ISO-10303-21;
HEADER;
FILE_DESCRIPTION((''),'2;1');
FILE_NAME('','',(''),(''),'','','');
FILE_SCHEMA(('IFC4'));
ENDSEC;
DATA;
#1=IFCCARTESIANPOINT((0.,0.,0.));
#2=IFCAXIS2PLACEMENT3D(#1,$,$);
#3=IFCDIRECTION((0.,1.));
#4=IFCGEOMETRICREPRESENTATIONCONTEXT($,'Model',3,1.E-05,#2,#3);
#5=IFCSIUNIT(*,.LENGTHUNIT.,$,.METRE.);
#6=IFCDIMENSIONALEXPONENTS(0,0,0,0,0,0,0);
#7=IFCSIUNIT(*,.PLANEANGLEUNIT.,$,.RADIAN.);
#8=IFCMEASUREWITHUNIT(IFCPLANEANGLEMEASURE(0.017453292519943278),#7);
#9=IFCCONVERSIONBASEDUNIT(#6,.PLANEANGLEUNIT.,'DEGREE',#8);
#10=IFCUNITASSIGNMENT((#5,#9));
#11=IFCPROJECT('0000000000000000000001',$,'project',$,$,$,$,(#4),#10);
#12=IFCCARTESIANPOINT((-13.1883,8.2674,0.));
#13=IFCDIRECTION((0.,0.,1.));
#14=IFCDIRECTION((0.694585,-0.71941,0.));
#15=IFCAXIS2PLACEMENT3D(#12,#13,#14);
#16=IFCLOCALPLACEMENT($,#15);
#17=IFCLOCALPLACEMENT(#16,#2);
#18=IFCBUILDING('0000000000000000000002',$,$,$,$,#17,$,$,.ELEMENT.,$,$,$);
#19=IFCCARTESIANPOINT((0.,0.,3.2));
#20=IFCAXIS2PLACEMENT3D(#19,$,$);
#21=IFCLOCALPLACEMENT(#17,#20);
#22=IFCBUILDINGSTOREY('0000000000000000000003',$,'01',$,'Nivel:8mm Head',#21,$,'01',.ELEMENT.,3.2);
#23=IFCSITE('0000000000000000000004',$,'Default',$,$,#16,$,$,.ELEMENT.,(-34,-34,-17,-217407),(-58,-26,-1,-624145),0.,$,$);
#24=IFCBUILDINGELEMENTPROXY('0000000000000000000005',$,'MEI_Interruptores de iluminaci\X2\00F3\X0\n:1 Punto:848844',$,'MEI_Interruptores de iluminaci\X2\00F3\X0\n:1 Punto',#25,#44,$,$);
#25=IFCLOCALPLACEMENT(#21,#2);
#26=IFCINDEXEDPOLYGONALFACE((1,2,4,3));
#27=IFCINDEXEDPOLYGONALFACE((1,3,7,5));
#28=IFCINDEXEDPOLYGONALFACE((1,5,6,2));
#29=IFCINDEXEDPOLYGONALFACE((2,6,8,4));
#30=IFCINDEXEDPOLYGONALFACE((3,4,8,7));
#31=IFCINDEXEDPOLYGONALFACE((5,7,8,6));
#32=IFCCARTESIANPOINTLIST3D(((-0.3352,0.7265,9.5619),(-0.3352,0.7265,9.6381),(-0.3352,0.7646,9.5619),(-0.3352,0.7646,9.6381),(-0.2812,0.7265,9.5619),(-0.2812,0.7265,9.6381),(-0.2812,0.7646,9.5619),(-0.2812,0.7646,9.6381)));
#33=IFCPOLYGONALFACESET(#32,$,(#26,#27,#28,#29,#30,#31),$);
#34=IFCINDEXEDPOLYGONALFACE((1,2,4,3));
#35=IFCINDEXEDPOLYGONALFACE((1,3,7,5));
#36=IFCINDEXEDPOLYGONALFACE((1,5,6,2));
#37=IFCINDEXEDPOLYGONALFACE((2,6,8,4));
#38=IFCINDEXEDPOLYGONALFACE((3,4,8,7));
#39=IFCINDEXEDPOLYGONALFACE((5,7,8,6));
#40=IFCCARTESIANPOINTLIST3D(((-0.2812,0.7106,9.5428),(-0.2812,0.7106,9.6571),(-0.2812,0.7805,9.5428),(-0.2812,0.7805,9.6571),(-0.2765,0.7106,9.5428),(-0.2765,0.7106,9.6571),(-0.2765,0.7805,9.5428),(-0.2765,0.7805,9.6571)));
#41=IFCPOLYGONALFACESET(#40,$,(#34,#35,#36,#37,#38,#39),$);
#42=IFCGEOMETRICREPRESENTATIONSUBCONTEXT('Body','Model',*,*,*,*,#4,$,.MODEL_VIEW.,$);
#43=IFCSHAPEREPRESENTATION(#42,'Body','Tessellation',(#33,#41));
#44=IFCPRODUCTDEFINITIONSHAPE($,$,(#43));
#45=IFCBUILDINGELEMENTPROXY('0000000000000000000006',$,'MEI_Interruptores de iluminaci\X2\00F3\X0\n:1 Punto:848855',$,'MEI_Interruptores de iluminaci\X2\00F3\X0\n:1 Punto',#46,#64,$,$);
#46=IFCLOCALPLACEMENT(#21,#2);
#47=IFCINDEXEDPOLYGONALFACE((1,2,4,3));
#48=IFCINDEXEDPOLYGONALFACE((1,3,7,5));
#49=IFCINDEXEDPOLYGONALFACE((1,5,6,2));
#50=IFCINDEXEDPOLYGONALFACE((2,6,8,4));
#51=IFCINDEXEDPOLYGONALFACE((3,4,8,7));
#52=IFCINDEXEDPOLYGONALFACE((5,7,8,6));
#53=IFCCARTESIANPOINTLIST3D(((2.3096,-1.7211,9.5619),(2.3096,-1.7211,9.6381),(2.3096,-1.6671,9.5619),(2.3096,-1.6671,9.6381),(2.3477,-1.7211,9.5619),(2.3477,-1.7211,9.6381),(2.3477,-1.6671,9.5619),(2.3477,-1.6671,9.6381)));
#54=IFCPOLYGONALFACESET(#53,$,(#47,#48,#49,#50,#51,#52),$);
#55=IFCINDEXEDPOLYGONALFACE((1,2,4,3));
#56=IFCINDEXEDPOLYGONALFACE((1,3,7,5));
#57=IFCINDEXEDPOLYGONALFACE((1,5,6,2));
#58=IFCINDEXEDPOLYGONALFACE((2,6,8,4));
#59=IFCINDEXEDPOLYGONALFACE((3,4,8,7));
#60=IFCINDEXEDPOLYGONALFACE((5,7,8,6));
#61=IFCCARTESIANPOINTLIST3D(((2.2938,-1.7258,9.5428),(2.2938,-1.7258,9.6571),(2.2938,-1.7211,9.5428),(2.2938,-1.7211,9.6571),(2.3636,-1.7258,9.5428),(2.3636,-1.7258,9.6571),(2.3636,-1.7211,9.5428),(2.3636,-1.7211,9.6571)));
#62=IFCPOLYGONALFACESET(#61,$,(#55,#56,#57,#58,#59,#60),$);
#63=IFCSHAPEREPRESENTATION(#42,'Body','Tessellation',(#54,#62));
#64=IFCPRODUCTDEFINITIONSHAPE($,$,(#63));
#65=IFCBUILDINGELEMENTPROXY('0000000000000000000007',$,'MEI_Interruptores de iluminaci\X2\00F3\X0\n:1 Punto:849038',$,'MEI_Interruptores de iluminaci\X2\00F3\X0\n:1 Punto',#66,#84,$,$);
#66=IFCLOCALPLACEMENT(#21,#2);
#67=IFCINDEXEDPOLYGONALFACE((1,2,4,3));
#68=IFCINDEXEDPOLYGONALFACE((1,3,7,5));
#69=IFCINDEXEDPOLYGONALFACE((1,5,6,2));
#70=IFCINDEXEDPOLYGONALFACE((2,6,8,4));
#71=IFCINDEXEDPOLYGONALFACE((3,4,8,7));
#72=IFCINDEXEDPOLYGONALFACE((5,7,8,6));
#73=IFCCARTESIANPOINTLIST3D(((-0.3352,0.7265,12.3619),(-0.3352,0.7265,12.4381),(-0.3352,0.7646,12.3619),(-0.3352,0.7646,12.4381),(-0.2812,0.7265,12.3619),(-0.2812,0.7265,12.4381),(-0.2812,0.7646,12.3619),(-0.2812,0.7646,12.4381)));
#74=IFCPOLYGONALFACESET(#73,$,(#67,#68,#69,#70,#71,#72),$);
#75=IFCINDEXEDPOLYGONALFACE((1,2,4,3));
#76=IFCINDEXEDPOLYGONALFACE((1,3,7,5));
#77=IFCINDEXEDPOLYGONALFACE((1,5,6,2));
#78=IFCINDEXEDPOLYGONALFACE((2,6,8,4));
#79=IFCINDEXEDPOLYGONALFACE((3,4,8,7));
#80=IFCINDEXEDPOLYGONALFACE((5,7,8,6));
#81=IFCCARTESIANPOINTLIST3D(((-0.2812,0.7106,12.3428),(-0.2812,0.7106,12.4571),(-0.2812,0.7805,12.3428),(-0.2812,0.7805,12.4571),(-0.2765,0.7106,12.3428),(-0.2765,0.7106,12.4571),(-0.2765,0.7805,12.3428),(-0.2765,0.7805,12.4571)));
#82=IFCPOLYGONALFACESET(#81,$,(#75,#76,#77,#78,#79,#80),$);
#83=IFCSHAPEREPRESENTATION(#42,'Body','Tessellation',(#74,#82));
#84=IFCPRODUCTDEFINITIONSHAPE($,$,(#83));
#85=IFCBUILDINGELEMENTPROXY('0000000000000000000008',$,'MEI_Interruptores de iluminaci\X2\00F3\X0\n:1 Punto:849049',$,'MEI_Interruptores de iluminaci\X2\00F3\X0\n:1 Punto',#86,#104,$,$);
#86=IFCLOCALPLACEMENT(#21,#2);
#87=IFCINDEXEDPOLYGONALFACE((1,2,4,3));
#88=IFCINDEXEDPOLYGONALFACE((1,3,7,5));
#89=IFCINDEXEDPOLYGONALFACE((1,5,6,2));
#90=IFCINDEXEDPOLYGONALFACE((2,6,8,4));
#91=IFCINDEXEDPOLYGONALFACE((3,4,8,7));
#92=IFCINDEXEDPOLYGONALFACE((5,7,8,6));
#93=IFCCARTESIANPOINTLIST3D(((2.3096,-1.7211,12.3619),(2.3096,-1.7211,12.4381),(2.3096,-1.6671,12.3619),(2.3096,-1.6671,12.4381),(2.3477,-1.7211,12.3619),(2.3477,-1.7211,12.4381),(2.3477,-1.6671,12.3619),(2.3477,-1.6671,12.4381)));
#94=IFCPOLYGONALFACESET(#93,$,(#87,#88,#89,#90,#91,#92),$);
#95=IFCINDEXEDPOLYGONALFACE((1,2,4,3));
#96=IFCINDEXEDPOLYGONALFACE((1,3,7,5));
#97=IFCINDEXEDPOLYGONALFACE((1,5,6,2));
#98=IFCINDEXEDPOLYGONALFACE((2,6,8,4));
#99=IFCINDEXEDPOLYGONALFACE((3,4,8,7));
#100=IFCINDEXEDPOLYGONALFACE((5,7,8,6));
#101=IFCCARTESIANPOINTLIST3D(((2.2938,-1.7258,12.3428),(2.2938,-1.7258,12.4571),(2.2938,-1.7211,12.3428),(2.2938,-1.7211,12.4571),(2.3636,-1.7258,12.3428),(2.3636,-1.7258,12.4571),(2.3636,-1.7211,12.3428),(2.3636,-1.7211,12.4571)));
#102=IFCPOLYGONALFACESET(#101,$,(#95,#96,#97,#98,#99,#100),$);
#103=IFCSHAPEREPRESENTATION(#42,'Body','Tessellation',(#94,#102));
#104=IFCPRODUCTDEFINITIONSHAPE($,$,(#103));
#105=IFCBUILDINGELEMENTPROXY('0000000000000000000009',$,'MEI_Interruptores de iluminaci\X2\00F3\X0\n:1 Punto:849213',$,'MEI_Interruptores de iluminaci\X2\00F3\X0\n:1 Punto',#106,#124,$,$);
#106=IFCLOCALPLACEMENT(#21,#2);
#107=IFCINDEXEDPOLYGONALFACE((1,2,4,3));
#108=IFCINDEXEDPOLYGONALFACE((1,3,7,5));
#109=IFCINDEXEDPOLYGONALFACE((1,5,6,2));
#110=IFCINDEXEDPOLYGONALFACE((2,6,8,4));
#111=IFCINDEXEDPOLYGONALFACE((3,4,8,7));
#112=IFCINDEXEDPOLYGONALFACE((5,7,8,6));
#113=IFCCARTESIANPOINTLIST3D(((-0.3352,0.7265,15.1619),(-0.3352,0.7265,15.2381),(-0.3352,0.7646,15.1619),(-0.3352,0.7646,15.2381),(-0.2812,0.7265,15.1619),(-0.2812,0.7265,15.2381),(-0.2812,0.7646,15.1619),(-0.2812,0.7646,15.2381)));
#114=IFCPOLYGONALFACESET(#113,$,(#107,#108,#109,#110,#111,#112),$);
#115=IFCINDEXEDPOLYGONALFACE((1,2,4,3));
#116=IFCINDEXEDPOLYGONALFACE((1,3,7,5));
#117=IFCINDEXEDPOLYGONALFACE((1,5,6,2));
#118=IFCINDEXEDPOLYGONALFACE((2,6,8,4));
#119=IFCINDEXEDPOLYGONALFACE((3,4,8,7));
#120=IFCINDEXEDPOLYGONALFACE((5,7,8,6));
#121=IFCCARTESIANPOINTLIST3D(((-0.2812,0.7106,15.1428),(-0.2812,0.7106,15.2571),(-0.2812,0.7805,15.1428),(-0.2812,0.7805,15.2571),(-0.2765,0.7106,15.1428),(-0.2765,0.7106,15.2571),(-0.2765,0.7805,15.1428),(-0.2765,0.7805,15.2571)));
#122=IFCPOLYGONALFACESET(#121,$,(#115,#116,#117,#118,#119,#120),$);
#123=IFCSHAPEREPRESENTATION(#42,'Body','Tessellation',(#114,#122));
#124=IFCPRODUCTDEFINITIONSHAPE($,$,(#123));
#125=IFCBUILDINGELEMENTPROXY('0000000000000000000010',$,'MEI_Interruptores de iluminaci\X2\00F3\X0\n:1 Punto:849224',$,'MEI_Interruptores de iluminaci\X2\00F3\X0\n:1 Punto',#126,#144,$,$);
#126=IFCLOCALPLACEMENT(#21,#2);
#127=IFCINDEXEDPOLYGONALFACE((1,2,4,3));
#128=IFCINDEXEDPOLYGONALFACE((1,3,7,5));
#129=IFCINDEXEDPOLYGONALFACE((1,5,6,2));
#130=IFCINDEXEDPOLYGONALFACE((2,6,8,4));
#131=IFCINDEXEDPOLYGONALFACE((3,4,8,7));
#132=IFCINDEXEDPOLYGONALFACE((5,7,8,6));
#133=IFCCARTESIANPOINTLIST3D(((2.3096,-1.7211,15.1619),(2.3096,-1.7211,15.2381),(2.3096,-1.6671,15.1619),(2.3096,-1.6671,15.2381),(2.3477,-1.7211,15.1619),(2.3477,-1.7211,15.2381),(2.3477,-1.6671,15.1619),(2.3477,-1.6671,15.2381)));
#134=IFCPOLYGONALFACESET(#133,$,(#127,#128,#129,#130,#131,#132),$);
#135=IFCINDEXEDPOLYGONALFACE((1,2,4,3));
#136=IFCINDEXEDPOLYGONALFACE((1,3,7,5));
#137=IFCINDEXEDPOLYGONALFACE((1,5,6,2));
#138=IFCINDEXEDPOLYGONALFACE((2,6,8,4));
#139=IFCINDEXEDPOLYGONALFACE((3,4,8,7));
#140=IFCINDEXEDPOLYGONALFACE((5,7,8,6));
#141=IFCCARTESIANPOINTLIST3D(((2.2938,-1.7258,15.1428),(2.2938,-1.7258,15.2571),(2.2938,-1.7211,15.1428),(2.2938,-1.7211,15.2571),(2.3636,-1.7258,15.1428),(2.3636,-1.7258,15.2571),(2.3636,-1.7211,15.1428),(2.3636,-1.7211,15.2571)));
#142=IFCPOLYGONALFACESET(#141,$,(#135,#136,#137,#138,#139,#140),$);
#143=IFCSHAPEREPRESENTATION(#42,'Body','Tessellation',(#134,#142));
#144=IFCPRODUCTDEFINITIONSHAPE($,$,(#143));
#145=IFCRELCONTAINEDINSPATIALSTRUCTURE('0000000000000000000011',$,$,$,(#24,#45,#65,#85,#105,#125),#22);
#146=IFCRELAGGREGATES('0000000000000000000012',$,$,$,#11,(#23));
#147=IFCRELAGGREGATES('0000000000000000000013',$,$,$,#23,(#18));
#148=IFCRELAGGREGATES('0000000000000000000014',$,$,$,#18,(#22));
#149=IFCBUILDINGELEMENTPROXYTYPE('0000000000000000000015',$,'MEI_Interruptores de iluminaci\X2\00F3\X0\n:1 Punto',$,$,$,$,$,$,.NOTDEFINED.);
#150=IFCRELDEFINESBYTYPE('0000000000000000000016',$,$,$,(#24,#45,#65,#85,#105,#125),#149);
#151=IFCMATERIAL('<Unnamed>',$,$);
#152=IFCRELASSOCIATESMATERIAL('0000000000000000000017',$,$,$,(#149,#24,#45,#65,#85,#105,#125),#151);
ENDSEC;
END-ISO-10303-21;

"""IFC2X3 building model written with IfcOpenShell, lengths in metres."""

from ifc_helpers import new_model, entity, si_unit, converted_unit, direction, frame, frame_2d, origin, origin_2d_with_axis, place, context, subcontext, project, spatial, rectangle, extrude, source, transform, mapped, material, type_object, type_shapes, element, save


model = new_model("IFC2X3")

# Units and contexts
model_context = context("Model", 3, precision=1e-05, world=origin(), true_north=direction((0.0, 1.0)))
body_context = subcontext(model_context, "Body", "Model", "MODEL_VIEW")
ifc_project = project(units=[si_unit("LENGTHUNIT", "METRE"), converted_unit("PLANEANGLEUNIT", "DEGREE", entity("IfcPlaneAngleMeasure", 0.017453292519943278), si_unit("PLANEANGLEUNIT", "RADIAN"), dimensions=[0, 0, 0, 0, 0, 0, 0])], contexts=[model_context])

# Site, building, storey
site_placement = place(None, frame((-13.1883, 8.2674, 0.0), z_axis=(0.0, 0.0, 1.0), x_axis=(0.694585, -0.71941, 0.0)))
site = spatial("IfcSite", under=ifc_project, at=site_placement, Name="Default", CompositionType="ELEMENT", RefLatitude=(-34, -34, -17, -217407), RefLongitude=(-58, -26, -1, -624145), RefElevation=0.0)
building_placement = place(site_placement, origin())
building = spatial("IfcBuilding", under=site, at=building_placement, CompositionType="ELEMENT")
storey_placement = place(building_placement, frame((0.0, 0.0, 3.2)))
storey = spatial("IfcBuildingStorey", under=building, at=storey_placement, Name="01", ObjectType="Nivel:8mm Head", LongName="01", CompositionType="ELEMENT", Elevation=3.2)

# Building element proxies
ifc_material_1 = material(Name="<Unnamed>")
building_element_proxy_type_1 = type_object("IfcBuildingElementProxyType", Name="MEI_Interruptores de iluminación:1 Punto", PredefinedType="NOTDEFINED", material=ifc_material_1)
shared_shape_1 = source(origin(), body_context, "Body", "SweptSolid", [
    extrude(rectangle(XDim=0.0381, YDim=0.0762, at=origin_2d_with_axis()), frame((0.0, 0.0, -0.054), z_axis=(0.0, 0.0, 1.0), x_axis=(-1.0, 0.0, 0.0)), (0.0, 0.0, 1.0), 0.054),
    extrude(rectangle(XDim=0.0698, YDim=0.1143, at=frame_2d((0.0, 0.0), x_axis=(1.0, 0.0))), frame((0.0, 0.0, 0.0), z_axis=(0.0, 0.0, 1.0), x_axis=(-1.0, 0.0, 0.0)), (0.0, 0.0, 1.0), 0.0048),
])
type_shapes(building_element_proxy_type_1, [shared_shape_1])
for number, where, z_axis, x_axis, name in (
    (1, (-0.2812, 0.7456, 9.6), (1.0, 0.0, 0.0), (0.0, 1.0, 0.0), "MEI_Interruptores de iluminación:1 Punto:848844"),
    (2, (2.3287, -1.7211, 9.6), (0.0, -1.0, 0.0), (1.0, 0.0, 0.0), "MEI_Interruptores de iluminación:1 Punto:848855"),
    (3, (-0.2812, 0.7456, 12.4), (1.0, 0.0, 0.0), (0.0, 1.0, 0.0), "MEI_Interruptores de iluminación:1 Punto:849038"),
    (4, (2.3287, -1.7211, 12.4), (0.0, -1.0, 0.0), (1.0, 0.0, 0.0), "MEI_Interruptores de iluminación:1 Punto:849049"),
    (5, (-0.2812, 0.7456, 15.2), (1.0, 0.0, 0.0), (0.0, 1.0, 0.0), "MEI_Interruptores de iluminación:1 Punto:849213"),
    (6, (2.3287, -1.7211, 15.2), (0.0, -1.0, 0.0), (1.0, 0.0, 0.0), "MEI_Interruptores de iluminación:1 Punto:849224"),
):
    element("IfcBuildingElementProxy", number, at=place(storey_placement, frame(where, z_axis=z_axis, x_axis=x_axis)), inside=storey, type_object=building_element_proxy_type_1, material=ifc_material_1, Name=name, ObjectType="MEI_Interruptores de iluminación:1 Punto", context=body_context, shape_type="MappedRepresentation", body=[
        mapped(shared_shape_1, transform((0.0, 0.0, 0.0), scale=1.0)),
    ])

save(model, "model.ifc")
